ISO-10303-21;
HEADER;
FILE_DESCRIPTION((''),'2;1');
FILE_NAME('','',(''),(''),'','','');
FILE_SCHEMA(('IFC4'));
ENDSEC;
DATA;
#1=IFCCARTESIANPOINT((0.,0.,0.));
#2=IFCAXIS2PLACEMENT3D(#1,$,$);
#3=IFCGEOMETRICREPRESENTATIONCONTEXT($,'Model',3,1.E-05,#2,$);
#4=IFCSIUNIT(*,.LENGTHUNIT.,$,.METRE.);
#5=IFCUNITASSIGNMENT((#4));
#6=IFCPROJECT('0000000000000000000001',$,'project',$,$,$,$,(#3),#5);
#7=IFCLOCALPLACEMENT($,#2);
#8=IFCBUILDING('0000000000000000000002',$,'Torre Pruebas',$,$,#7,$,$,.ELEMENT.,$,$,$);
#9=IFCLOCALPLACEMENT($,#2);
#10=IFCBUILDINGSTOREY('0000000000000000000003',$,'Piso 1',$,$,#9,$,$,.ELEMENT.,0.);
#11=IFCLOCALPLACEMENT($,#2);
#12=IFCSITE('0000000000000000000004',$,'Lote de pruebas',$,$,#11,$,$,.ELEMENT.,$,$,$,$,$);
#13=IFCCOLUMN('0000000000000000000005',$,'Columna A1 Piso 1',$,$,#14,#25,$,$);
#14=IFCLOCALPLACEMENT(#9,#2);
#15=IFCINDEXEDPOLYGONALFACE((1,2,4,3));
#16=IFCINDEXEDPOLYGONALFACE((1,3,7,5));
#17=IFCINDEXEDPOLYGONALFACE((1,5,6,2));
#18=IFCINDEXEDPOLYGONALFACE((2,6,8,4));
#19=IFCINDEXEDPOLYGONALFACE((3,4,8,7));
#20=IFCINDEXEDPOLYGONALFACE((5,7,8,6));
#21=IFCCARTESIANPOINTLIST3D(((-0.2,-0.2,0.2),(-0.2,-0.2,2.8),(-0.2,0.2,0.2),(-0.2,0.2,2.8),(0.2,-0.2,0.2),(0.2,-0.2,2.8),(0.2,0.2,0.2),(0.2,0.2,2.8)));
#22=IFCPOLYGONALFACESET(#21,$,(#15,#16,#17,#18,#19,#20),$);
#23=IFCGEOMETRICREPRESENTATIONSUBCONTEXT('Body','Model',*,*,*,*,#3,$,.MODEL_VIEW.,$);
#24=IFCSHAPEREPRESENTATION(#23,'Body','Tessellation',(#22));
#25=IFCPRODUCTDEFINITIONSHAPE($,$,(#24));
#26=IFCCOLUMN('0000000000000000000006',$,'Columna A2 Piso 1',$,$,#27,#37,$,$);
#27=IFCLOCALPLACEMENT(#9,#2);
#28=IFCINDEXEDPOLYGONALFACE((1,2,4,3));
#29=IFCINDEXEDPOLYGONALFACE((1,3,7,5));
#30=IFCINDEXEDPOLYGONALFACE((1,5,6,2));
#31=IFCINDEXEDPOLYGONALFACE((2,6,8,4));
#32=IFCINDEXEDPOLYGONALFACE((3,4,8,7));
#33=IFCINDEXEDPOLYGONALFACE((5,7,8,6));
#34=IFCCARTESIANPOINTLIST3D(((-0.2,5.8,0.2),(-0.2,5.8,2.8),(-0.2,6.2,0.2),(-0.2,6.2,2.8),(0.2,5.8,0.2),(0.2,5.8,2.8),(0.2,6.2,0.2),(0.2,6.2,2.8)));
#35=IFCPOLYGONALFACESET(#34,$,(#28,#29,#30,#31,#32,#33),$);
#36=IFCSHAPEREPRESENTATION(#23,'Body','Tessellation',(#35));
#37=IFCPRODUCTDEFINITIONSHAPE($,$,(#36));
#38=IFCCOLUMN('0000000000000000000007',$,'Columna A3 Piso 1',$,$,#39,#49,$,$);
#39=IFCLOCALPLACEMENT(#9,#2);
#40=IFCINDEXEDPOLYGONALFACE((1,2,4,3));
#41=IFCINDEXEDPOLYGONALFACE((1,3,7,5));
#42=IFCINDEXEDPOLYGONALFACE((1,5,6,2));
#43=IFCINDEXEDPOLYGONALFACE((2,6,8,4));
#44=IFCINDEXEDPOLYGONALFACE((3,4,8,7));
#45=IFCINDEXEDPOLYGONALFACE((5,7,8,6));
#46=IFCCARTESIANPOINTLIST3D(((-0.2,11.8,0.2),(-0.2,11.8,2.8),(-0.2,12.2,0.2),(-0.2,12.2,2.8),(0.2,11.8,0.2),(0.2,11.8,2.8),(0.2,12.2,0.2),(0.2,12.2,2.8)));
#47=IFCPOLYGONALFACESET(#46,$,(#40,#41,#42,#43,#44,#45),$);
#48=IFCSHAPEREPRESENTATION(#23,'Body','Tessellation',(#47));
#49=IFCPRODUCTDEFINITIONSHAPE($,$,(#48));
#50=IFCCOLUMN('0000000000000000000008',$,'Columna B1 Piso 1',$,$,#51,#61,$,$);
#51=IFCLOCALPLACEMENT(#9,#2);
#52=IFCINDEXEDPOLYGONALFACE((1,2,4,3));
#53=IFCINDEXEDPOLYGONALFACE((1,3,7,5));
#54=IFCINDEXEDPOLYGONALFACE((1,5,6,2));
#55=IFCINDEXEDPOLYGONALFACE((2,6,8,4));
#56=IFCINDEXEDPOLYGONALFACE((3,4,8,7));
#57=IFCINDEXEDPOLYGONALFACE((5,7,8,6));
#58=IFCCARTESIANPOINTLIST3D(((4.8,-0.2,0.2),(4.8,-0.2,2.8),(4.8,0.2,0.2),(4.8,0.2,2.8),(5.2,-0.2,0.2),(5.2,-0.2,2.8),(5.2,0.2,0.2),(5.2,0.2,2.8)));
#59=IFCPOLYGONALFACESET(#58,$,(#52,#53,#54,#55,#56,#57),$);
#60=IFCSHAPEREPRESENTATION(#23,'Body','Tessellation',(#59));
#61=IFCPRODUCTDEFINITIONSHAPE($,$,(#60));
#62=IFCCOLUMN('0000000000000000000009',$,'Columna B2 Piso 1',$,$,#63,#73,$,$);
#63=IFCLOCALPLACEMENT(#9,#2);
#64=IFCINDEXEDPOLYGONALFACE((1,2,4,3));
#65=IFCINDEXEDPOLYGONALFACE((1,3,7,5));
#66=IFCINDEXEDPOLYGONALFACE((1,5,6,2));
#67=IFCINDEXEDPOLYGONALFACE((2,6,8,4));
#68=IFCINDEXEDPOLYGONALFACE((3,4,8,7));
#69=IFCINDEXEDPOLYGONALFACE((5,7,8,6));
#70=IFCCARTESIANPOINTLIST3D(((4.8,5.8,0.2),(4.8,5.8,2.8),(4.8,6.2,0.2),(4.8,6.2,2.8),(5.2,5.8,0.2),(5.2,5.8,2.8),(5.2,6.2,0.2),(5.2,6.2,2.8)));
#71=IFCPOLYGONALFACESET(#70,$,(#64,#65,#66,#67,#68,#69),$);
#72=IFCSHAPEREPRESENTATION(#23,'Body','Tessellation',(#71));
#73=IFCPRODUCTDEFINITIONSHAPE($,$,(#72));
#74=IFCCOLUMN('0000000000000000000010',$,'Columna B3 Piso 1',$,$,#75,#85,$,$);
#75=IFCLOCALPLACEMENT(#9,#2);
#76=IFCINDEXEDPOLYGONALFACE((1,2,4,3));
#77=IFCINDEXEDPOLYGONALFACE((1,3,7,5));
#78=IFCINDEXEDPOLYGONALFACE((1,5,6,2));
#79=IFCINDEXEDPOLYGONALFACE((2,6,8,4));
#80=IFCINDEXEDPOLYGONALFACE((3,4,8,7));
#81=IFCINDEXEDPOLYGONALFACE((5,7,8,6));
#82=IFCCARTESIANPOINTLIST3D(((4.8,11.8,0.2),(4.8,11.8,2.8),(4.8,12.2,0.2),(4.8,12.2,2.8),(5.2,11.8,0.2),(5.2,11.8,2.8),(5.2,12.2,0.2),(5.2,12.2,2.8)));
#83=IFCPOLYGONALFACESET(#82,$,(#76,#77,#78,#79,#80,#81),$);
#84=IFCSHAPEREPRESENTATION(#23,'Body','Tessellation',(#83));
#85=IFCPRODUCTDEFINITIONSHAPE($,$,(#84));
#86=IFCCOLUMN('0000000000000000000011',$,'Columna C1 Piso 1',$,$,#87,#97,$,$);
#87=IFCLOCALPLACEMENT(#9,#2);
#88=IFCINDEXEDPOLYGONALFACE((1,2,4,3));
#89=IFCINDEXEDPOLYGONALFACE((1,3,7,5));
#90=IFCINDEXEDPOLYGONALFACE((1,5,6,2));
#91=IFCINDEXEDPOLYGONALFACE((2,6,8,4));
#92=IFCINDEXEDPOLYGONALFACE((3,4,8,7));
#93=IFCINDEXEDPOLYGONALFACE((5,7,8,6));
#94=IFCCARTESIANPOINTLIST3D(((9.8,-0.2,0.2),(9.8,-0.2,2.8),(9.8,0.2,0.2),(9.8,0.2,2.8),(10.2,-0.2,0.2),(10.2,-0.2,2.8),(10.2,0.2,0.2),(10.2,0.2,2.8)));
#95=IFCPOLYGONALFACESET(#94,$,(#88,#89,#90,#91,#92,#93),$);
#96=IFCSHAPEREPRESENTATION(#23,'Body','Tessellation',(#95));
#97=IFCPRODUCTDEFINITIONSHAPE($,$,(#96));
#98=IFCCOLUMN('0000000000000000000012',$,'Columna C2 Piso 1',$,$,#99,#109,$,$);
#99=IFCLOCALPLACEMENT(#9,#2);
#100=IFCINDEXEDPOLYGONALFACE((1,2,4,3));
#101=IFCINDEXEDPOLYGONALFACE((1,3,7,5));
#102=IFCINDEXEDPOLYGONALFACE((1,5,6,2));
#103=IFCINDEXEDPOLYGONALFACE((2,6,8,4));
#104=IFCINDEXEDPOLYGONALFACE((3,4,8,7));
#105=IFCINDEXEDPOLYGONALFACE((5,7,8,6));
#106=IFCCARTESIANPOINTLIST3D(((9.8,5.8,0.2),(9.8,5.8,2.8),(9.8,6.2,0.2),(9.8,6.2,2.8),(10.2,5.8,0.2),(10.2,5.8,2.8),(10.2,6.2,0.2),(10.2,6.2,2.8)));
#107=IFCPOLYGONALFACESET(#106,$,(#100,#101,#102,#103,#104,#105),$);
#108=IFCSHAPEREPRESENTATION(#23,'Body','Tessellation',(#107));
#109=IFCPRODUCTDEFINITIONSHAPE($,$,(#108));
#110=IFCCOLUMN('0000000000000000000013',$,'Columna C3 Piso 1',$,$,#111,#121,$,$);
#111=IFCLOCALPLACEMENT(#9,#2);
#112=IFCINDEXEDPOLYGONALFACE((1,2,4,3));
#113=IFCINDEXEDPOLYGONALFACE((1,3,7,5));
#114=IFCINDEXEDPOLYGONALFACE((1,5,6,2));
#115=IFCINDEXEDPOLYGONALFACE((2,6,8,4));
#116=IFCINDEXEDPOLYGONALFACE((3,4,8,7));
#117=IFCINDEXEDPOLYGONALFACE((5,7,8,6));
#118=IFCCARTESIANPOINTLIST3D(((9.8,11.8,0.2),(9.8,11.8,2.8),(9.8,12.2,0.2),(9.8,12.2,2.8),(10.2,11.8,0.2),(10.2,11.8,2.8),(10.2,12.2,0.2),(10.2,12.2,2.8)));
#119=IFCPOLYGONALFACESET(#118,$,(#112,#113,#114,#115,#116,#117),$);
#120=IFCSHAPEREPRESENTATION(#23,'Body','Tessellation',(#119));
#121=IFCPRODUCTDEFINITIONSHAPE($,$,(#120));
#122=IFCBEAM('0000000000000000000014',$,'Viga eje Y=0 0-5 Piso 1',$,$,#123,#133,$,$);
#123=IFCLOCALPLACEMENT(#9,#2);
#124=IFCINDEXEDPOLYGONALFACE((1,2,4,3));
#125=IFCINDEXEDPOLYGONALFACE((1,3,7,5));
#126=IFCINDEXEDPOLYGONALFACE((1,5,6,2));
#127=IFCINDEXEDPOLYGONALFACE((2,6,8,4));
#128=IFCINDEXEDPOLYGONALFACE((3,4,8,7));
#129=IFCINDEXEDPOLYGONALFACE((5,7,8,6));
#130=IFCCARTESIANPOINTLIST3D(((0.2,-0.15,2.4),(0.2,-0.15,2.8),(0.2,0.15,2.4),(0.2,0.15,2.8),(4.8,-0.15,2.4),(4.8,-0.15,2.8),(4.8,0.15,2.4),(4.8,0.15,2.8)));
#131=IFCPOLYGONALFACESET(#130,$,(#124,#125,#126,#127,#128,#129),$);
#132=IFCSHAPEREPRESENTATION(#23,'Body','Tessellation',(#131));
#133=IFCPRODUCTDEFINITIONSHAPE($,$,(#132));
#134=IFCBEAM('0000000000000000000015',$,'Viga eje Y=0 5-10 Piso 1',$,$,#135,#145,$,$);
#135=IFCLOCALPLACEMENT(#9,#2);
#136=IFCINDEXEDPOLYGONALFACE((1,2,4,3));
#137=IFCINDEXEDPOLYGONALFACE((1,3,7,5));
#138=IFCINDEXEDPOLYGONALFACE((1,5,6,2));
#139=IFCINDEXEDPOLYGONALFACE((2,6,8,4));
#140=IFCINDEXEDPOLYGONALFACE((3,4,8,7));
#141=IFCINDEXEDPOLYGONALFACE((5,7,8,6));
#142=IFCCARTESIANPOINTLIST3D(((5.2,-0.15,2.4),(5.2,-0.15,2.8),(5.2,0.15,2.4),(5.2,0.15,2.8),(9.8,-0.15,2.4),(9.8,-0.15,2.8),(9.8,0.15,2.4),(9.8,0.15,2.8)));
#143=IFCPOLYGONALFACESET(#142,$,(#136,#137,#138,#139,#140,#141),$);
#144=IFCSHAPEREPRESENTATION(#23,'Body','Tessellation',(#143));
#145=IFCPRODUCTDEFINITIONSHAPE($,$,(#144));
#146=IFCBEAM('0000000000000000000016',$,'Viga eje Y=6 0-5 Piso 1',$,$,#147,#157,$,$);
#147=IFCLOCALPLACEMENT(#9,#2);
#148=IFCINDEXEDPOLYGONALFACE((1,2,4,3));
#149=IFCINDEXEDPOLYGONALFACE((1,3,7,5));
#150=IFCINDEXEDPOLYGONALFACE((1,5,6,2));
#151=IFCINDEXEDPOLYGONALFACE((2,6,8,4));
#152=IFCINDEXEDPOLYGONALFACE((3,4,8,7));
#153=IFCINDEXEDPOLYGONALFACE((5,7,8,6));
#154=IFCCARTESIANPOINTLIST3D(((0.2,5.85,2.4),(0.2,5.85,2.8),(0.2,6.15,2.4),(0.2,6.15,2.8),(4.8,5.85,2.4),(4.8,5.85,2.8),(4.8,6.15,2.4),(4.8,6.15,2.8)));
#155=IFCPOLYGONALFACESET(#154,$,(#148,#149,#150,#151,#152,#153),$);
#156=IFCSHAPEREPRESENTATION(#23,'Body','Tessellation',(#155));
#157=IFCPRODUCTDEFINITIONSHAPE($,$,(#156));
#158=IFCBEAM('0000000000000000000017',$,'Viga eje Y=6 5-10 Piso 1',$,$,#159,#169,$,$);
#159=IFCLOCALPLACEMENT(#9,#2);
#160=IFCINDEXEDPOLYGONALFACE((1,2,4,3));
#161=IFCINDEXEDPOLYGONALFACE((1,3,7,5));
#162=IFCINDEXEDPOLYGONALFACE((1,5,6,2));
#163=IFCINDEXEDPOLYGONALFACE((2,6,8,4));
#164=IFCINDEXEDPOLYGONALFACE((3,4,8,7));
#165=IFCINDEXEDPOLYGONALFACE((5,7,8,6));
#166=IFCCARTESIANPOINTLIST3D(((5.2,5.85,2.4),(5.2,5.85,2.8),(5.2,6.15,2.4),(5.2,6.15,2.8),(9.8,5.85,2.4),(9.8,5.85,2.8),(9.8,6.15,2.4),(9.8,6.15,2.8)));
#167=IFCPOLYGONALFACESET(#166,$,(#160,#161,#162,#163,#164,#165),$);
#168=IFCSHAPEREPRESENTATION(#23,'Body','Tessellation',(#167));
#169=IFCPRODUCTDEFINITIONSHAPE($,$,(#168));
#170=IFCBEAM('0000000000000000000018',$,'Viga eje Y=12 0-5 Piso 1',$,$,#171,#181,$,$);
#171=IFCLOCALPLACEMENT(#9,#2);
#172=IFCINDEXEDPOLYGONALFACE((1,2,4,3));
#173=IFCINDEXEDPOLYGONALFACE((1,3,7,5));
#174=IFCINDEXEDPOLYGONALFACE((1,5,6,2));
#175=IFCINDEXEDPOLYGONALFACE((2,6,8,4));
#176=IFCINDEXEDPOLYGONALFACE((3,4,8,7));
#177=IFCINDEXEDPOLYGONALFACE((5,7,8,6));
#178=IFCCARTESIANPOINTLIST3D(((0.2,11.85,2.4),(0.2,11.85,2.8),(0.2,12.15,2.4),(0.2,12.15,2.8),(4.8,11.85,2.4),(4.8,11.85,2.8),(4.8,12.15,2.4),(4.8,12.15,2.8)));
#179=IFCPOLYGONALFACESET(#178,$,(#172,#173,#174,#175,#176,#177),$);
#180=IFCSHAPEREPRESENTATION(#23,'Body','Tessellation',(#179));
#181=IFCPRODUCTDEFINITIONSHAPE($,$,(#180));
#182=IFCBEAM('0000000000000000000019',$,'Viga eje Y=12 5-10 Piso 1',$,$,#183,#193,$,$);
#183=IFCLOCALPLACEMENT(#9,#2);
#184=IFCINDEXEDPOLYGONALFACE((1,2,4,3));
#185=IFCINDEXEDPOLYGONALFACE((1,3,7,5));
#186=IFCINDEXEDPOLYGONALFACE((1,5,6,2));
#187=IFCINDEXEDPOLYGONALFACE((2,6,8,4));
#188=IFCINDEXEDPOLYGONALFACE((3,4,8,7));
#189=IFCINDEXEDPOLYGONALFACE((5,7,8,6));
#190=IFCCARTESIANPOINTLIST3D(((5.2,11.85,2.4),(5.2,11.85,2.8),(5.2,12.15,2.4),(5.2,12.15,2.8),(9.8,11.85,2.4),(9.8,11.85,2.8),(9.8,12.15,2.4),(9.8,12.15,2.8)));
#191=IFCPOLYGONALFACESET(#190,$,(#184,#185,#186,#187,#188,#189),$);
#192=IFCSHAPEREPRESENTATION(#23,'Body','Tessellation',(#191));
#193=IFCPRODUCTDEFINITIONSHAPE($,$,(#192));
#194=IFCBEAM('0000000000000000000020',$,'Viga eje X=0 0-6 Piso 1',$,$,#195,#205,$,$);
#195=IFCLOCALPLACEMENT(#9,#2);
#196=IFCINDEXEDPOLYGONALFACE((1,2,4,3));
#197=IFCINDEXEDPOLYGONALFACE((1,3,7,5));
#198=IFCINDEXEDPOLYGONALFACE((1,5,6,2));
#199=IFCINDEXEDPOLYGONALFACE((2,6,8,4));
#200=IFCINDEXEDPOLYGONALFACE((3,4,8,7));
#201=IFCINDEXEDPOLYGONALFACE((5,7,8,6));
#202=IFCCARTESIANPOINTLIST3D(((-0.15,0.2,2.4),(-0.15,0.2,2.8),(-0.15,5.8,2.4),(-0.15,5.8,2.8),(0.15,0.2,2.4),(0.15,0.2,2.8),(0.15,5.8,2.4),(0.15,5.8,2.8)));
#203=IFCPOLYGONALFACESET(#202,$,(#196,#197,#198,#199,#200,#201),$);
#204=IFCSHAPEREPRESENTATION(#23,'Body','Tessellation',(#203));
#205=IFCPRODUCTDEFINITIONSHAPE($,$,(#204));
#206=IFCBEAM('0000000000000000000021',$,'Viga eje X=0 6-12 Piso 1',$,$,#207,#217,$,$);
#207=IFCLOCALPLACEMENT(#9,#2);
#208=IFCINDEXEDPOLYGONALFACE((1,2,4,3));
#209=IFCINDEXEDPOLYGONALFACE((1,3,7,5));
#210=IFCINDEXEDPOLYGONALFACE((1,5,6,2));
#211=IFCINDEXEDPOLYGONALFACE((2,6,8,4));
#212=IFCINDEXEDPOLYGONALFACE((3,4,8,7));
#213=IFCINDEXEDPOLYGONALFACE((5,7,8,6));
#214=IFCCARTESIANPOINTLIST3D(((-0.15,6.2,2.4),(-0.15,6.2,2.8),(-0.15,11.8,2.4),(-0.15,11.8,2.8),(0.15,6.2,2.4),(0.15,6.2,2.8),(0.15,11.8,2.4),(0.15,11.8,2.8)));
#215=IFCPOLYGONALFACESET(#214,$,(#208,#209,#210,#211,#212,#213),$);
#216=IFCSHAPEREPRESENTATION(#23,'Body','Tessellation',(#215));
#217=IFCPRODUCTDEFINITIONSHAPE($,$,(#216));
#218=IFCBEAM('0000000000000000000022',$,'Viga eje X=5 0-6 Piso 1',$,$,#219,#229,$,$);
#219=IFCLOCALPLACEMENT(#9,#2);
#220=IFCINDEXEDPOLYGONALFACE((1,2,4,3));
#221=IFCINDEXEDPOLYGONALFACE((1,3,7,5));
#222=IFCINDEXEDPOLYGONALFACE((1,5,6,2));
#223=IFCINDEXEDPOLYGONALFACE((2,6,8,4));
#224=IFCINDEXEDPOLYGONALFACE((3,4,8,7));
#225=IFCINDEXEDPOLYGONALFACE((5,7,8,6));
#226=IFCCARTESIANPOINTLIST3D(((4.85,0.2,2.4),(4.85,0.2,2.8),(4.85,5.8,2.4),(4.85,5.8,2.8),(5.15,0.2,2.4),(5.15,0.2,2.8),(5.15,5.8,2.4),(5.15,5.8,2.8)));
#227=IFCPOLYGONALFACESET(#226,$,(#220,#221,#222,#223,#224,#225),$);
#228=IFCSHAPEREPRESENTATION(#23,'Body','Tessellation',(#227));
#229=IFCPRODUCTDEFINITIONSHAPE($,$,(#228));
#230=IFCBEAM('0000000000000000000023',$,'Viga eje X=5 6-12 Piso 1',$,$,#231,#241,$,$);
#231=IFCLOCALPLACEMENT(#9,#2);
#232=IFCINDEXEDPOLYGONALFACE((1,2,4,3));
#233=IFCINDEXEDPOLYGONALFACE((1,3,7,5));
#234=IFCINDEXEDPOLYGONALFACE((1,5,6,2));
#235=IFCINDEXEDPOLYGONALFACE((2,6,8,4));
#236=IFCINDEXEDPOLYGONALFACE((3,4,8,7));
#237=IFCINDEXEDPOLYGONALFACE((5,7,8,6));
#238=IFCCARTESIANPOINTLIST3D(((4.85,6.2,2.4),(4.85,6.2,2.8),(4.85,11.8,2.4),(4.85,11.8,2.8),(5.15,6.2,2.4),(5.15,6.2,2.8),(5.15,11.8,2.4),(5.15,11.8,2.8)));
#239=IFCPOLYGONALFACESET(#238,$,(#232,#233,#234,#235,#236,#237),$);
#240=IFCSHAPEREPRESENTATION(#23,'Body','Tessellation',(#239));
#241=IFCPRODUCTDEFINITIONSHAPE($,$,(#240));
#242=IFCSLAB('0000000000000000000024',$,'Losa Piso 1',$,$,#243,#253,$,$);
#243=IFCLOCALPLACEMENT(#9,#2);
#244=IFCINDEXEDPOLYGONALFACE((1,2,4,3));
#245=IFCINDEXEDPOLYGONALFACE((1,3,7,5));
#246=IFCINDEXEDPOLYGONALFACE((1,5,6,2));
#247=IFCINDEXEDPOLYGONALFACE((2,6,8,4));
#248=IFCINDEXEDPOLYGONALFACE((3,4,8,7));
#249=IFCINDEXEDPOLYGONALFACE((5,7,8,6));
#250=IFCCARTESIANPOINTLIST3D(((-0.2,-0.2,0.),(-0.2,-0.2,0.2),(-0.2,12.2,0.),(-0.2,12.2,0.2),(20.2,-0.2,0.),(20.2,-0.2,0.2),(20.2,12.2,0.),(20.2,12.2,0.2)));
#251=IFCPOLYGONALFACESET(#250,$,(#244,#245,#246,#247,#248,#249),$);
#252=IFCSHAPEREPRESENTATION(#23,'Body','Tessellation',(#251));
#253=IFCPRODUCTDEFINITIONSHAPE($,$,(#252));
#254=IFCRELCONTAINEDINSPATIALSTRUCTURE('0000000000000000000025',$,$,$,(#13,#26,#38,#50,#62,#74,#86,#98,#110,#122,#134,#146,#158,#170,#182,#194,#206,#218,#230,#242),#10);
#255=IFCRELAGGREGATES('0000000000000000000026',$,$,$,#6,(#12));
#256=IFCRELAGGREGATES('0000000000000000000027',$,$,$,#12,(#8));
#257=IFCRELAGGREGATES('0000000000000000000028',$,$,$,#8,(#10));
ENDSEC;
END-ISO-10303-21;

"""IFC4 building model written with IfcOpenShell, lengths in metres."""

from ifc_helpers import new_model, si_unit, frame, origin, origin_2d, place, context, subcontext, project, spatial, rectangle, extrude, element, save


model = new_model("IFC4")

# Units and contexts
model_context = context("Model", 3, precision=1e-05, world=origin())
body_context = subcontext(model_context, "Body", "Model", "MODEL_VIEW")
ifc_project = project(units=[si_unit("LENGTHUNIT", "METRE")], contexts=[model_context])

# Site, building, storey
site_placement = place(None, origin())
site = spatial("IfcSite", under=ifc_project, at=site_placement, Name="Lote de pruebas", CompositionType="ELEMENT")
building_placement = place(None, origin())
building = spatial("IfcBuilding", under=site, at=building_placement, Name="Torre Pruebas", CompositionType="ELEMENT")
storey_placement = place(None, origin())
storey = spatial("IfcBuildingStorey", under=building, at=storey_placement, Name="Piso 1", CompositionType="ELEMENT", Elevation=0.0)

# Columns
for number, where, name in (
    (1, (0.0, 0.0, 0.2), "Columna A1 Piso 1"),
    (2, (0.0, 6.0, 0.2), "Columna A2 Piso 1"),
    (3, (0.0, 12.0, 0.2), "Columna A3 Piso 1"),
    (4, (5.0, 0.0, 0.2), "Columna B1 Piso 1"),
    (5, (5.0, 6.0, 0.2), "Columna B2 Piso 1"),
    (6, (5.0, 12.0, 0.2), "Columna B3 Piso 1"),
    (7, (10.0, 0.0, 0.2), "Columna C1 Piso 1"),
    (8, (10.0, 6.0, 0.2), "Columna C2 Piso 1"),
    (9, (10.0, 12.0, 0.2), "Columna C3 Piso 1"),
):
    element("IfcColumn", number, at=place(None, frame(where)), inside=storey, Name=name, context=body_context, shape_type="SweptSolid", body=[
        extrude(rectangle(XDim=0.4, YDim=0.4, at=origin_2d()), origin(), (0.0, 0.0, 1.0), 2.6),
    ])

# Beams
for number, where, name in (
    (10, (2.5, 0.0, 2.4), "Viga eje Y=0 0-5 Piso 1"),
    (11, (7.5, 0.0, 2.4), "Viga eje Y=0 5-10 Piso 1"),
    (12, (2.5, 6.0, 2.4), "Viga eje Y=6 0-5 Piso 1"),
    (13, (7.5, 6.0, 2.4), "Viga eje Y=6 5-10 Piso 1"),
    (14, (2.5, 12.0, 2.4), "Viga eje Y=12 0-5 Piso 1"),
    (15, (7.5, 12.0, 2.4), "Viga eje Y=12 5-10 Piso 1"),
):
    element("IfcBeam", number, at=place(None, frame(where)), inside=storey, Name=name, context=body_context, shape_type="SweptSolid", body=[
        extrude(rectangle(XDim=4.6, YDim=0.3, at=origin_2d()), origin(), (0.0, 0.0, 1.0), 0.4),
    ])
for number, where, name in (
    (16, (0.0, 3.0, 2.4), "Viga eje X=0 0-6 Piso 1"),
    (17, (0.0, 9.0, 2.4), "Viga eje X=0 6-12 Piso 1"),
    (18, (5.0, 3.0, 2.4), "Viga eje X=5 0-6 Piso 1"),
    (19, (5.0, 9.0, 2.4), "Viga eje X=5 6-12 Piso 1"),
):
    element("IfcBeam", number, at=place(None, frame(where)), inside=storey, Name=name, context=body_context, shape_type="SweptSolid", body=[
        extrude(rectangle(XDim=0.3, YDim=5.6, at=origin_2d()), origin(), (0.0, 0.0, 1.0), 0.4),
    ])

# Slab
slab_placement = place(None, frame((10.0, 6.0, 0.0)))
element("IfcSlab", 20, at=slab_placement, inside=storey, Name="Losa Piso 1", context=body_context, shape_type="SweptSolid", body=[
    extrude(rectangle(XDim=20.4, YDim=12.4, at=origin_2d()), origin(), (0.0, 0.0, 1.0), 0.2),
])

save(model, "model.ifc")
